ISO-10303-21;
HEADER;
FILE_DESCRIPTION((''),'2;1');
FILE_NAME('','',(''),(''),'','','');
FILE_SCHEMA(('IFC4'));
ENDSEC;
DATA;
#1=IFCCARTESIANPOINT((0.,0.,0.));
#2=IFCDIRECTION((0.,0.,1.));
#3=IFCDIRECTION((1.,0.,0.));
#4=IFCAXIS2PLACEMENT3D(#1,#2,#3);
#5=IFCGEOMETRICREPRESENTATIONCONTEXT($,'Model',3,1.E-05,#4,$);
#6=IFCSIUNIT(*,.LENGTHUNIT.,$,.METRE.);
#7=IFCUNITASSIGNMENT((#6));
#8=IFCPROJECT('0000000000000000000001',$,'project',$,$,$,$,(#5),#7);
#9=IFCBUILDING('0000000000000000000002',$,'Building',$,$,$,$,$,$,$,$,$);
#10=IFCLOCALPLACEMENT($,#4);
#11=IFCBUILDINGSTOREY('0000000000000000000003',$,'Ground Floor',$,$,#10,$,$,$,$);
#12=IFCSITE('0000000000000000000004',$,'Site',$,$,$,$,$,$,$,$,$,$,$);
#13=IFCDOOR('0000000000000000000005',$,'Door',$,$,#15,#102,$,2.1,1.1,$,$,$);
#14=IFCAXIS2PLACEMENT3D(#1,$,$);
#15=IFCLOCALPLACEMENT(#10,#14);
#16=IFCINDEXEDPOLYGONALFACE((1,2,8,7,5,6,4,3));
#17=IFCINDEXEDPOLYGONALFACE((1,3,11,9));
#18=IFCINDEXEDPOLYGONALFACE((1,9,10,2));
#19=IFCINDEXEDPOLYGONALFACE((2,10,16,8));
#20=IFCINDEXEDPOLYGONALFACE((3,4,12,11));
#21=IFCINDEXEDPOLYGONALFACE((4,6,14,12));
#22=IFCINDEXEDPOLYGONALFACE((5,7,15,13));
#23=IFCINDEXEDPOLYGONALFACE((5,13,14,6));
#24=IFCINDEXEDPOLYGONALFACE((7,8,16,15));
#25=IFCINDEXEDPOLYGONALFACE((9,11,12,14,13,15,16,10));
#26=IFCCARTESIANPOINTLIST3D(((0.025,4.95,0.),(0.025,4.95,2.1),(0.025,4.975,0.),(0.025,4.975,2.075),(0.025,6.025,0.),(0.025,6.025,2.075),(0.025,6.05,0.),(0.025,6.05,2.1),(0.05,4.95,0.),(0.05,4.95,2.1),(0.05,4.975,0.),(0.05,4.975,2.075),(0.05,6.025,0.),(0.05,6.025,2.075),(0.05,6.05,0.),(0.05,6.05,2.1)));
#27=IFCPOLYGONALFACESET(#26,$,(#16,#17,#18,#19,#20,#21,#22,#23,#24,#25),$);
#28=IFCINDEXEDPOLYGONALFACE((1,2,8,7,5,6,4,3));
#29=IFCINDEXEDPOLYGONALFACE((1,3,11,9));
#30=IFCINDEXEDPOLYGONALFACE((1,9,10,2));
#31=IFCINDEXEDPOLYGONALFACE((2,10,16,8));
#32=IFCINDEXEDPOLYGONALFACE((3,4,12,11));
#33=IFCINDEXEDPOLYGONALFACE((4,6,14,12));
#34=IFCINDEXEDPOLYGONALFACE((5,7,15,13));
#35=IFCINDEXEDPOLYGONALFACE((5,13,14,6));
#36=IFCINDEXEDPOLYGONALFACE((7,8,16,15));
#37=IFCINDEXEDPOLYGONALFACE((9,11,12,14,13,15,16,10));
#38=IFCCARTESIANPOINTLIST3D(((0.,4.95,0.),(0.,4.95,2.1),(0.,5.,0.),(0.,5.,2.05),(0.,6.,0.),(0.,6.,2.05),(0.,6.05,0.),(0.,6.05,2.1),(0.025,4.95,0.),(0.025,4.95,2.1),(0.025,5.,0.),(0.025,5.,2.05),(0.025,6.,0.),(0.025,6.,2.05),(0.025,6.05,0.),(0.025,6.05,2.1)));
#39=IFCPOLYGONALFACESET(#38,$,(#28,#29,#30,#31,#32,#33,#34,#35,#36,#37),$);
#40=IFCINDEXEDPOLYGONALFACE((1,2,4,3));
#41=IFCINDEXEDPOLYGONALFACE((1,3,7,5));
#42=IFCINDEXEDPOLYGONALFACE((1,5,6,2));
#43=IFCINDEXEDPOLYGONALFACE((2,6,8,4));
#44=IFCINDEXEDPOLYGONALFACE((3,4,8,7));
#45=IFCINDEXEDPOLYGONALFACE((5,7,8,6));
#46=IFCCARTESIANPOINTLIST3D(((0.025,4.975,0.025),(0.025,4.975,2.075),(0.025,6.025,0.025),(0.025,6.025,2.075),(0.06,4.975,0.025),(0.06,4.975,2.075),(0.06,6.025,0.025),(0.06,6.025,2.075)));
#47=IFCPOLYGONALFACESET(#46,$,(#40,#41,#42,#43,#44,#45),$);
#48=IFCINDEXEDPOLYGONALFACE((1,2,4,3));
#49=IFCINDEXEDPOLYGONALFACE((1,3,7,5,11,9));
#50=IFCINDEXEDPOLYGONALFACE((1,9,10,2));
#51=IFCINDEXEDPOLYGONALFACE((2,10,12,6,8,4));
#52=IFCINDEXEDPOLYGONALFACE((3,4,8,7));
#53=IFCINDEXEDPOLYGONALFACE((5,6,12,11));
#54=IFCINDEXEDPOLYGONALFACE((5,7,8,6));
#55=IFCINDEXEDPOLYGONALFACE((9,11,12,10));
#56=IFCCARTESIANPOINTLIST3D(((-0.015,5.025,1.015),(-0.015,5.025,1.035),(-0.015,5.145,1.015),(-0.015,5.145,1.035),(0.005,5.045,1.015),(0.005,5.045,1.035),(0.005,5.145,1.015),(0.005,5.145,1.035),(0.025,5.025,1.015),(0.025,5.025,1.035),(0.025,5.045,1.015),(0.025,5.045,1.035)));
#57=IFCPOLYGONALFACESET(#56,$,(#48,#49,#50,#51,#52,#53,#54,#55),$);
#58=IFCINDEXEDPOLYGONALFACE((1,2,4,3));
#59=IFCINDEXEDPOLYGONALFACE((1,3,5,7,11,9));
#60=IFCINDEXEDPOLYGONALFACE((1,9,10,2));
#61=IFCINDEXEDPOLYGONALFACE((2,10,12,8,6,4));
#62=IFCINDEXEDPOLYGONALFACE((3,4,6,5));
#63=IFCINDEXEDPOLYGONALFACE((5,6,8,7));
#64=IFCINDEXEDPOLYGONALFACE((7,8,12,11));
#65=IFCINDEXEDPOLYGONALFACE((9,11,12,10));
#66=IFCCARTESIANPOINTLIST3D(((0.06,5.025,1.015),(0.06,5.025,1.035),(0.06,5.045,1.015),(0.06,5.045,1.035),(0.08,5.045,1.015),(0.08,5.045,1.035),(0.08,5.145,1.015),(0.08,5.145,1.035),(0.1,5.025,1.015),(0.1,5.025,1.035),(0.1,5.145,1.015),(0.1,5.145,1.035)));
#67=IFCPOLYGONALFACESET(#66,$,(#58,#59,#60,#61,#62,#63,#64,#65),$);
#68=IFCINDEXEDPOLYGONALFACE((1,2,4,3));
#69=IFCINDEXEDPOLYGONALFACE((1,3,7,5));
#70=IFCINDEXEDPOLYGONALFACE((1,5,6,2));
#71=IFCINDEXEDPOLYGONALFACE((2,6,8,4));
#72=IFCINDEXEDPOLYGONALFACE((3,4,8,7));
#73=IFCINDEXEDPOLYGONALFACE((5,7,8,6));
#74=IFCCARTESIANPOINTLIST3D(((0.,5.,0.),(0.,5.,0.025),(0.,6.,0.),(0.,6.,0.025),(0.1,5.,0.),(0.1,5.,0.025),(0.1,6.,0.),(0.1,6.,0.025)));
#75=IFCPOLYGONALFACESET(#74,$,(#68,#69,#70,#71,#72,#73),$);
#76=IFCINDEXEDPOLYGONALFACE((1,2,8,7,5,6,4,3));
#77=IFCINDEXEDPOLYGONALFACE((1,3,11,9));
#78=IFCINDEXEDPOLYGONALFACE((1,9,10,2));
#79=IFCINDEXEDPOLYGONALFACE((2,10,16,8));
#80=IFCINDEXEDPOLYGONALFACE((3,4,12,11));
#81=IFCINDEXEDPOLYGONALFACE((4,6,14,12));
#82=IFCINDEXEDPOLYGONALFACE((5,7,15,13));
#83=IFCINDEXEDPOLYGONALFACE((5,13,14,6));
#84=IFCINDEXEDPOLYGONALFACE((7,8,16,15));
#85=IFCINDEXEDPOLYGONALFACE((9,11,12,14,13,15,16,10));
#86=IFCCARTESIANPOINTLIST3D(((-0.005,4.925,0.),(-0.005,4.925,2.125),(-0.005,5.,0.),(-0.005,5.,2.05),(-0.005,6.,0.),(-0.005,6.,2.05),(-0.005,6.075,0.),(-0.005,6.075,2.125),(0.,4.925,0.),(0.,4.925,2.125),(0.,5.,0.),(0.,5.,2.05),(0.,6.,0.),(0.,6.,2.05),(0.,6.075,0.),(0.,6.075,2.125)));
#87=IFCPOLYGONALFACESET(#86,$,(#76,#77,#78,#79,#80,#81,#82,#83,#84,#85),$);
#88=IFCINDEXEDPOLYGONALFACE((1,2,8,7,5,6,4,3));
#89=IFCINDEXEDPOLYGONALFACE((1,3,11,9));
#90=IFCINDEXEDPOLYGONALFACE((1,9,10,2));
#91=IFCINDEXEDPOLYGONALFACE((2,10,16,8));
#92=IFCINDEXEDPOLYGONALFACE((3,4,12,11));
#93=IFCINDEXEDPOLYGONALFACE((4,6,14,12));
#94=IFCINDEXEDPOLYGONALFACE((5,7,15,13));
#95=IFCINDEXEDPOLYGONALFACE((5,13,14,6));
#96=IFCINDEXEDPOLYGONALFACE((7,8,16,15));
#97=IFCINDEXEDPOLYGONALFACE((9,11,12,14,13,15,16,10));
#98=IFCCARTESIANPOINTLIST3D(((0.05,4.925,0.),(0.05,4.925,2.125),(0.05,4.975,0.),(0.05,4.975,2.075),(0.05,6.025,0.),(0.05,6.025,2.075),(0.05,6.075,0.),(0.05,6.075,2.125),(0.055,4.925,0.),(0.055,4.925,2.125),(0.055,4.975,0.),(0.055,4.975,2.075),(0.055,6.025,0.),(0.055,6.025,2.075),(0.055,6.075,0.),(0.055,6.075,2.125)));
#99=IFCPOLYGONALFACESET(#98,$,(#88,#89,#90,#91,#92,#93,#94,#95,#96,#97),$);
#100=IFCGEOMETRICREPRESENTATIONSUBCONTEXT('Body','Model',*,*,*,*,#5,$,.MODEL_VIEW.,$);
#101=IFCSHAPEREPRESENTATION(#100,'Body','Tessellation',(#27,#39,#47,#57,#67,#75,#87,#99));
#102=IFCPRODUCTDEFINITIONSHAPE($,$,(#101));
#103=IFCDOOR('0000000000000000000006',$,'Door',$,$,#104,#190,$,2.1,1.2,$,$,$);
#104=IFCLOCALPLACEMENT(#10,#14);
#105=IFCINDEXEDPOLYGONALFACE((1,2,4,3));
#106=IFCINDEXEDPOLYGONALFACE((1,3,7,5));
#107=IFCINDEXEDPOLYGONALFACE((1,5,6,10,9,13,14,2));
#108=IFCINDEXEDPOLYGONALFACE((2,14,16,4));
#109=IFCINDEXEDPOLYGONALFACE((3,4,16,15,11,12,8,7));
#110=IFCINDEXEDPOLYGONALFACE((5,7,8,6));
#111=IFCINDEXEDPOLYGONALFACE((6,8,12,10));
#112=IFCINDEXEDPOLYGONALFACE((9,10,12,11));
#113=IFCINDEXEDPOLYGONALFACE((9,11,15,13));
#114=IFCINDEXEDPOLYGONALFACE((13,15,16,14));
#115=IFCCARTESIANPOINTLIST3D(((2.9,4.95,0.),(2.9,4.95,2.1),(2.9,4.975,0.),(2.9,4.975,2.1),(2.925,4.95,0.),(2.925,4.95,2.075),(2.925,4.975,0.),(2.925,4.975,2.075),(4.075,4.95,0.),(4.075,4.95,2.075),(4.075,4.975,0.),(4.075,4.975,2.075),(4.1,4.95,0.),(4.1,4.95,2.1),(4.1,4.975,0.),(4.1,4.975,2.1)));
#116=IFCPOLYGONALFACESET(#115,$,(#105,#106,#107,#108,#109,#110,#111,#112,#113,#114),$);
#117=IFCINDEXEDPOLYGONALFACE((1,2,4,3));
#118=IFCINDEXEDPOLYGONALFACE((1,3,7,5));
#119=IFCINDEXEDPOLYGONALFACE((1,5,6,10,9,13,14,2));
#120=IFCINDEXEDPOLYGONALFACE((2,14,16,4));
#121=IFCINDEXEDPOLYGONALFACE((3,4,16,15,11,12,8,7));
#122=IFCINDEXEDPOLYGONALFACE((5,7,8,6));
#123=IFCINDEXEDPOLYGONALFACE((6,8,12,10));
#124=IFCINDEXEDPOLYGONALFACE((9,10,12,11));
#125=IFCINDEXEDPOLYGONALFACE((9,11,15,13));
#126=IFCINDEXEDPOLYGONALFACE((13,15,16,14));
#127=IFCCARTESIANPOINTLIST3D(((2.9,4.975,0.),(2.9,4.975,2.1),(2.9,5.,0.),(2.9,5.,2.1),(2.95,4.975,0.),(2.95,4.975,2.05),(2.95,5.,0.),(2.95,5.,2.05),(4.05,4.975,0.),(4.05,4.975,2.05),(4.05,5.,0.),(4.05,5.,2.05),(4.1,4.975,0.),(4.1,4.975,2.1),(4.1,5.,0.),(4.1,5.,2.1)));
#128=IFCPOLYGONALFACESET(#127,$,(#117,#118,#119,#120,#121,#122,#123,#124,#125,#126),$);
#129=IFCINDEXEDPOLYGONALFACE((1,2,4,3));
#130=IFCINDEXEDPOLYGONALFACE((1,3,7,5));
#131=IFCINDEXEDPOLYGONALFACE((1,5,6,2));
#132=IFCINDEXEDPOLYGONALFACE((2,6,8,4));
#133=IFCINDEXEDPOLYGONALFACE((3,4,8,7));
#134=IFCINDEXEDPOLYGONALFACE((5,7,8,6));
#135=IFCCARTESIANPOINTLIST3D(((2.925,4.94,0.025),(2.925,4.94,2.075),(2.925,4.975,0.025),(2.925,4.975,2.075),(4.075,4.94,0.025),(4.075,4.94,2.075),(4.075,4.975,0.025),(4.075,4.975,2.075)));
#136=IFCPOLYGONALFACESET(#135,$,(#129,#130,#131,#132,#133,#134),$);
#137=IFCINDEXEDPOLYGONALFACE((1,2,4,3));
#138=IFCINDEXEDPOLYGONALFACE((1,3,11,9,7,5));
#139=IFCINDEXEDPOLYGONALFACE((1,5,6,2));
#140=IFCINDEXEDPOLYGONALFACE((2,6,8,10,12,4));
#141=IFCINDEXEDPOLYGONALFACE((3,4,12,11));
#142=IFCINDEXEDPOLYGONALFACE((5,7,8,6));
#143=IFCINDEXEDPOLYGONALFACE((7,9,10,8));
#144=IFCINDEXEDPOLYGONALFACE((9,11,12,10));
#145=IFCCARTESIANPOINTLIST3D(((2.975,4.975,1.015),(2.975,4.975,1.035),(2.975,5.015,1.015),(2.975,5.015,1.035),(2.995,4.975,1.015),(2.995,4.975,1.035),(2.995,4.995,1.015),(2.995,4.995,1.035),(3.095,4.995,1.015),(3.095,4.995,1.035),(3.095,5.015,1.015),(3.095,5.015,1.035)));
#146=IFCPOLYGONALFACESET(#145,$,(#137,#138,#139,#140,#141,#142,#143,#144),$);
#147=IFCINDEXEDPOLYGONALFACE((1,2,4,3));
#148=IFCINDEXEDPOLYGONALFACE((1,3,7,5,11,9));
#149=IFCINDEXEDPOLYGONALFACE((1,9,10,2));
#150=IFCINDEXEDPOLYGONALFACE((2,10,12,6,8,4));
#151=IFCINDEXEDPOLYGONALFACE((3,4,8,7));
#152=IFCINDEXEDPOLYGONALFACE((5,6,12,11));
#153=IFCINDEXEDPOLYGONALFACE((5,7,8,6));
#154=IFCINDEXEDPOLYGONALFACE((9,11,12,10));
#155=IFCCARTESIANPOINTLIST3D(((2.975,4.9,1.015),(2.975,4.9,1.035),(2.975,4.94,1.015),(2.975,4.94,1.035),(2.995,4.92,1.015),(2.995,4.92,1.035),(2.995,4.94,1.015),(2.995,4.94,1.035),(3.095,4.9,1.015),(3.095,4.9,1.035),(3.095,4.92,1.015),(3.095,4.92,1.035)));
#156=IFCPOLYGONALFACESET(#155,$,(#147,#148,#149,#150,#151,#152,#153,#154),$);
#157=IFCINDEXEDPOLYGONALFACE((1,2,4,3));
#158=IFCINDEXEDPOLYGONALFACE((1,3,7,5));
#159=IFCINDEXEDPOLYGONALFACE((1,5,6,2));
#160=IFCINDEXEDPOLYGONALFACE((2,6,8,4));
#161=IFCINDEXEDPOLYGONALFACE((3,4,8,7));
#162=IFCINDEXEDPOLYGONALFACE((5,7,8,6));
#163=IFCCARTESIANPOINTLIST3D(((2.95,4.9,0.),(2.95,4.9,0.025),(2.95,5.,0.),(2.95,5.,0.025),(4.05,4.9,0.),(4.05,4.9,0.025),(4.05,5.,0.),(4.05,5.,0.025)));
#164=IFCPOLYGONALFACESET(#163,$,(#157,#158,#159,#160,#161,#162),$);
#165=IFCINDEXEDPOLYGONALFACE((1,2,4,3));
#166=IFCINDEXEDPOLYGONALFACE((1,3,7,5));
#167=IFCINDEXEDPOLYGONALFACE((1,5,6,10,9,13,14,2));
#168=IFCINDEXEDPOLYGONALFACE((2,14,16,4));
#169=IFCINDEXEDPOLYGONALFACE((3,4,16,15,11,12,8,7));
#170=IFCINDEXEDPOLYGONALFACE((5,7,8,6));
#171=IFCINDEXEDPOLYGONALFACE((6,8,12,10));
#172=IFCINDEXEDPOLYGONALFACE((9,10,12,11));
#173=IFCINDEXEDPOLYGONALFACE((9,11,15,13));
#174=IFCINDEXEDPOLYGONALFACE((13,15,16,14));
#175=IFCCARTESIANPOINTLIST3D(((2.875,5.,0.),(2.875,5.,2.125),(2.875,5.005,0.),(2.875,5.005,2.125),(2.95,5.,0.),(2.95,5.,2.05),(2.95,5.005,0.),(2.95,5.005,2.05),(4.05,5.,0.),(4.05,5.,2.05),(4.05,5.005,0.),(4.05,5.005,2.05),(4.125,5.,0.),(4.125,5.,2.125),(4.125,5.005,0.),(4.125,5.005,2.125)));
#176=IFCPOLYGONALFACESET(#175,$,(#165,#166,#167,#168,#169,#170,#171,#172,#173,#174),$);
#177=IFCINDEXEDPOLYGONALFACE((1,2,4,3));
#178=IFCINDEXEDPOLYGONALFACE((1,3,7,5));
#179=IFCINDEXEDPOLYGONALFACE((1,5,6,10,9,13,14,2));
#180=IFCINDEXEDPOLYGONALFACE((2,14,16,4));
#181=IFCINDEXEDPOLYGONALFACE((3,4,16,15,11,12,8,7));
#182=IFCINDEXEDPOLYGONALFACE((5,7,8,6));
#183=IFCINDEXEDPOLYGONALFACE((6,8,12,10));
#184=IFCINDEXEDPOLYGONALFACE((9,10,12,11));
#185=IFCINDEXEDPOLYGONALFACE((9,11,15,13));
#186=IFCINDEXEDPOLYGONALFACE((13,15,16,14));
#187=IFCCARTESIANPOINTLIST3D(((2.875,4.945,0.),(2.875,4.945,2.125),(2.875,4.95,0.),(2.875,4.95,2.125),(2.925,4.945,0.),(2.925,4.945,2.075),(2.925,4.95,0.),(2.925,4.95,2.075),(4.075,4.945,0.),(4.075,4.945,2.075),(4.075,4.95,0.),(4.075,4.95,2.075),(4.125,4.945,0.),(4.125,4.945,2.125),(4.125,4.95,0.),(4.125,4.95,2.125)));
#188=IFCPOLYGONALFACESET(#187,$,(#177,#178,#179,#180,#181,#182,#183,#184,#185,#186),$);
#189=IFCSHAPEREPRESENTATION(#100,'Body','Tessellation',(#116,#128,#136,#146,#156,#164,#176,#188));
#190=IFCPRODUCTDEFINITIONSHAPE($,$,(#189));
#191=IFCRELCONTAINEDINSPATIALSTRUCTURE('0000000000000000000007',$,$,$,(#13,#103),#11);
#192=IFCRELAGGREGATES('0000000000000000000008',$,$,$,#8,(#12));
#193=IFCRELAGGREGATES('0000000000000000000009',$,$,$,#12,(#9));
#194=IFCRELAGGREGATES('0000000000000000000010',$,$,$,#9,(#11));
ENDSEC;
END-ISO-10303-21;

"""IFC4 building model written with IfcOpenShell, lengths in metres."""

from ifc_helpers import new_model, si_unit, frame, origin_with_axes, place, context, subcontext, project, spatial, line, indexed_curve, outline, extrude, element, save


model = new_model("IFC4")

# Units and contexts
model_context = context("Model", 3, precision=1e-05, world=origin_with_axes())
body_context = subcontext(model_context, "Body", "Model", "MODEL_VIEW")
ifc_project = project(units=[si_unit("LENGTHUNIT", "METRE")], contexts=[model_context])

# Site, building, storey
site = spatial("IfcSite", under=ifc_project, Name="Site")
building = spatial("IfcBuilding", under=site, Name="Building")
storey_placement = place(None, origin_with_axes())
storey = spatial("IfcBuildingStorey", under=building, at=storey_placement, Name="Ground Floor")

# Doors
door_1_placement = place(storey_placement, frame((0.0, 6.05, 0.0), z_axis=(0.0, 0.0, 1.0), x_axis=(0.0, -1.0, 0.0)))
element("IfcDoor", 1, at=door_1_placement, inside=storey, Name="Door", OverallHeight=2.1, OverallWidth=1.1, context=body_context, shape_type="SweptSolid", body=[
    extrude(outline(indexed_curve([(0.0, 0.0), (0.0, 2.1), (1.1, 2.1), (1.1, 0.0), (1.075, 0.0), (1.075, 2.075), (0.025, 2.075), (0.025, 0.0)], segments=[line(1, 2, 3, 4, 5, 6, 7, 8, 1)])), frame((0.0, 0.025, 0.0), z_axis=(0.0, -1.0, 0.0), x_axis=(1.0, 0.0, 0.0)), (0.0, 0.0, -1.0), 0.025),
    extrude(outline(indexed_curve([(0.0, 0.0), (0.0, 2.1), (1.1, 2.1), (1.1, 0.0), (1.05, 0.0), (1.05, 2.05), (0.05, 2.05), (0.05, 0.0)], segments=[line(1, 2, 3, 4, 5, 6, 7, 8, 1)])), frame((0.0, 0.0, 0.0), z_axis=(0.0, -1.0, 0.0), x_axis=(1.0, 0.0, 0.0)), (0.0, 0.0, -1.0), 0.025),
    extrude(outline(indexed_curve([(0.0, 0.0), (1.05, 0.0), (1.05, 0.035), (0.0, 0.035)], segments=[line(1, 2, 3, 4, 1)])), frame((0.025, 0.025, 0.025), z_axis=(0.0, 0.0, 1.0), x_axis=(1.0, 0.0, 0.0)), (0.0, 0.0, 1.0), 2.05),
    extrude(outline(indexed_curve([(0.0, 0.0), (0.0, -0.04), (-0.12, -0.04), (-0.12, -0.02), (-0.02, -0.02), (-0.02, 0.0)], segments=[line(1, 2, 3, 4, 5, 6, 1)])), frame((1.025, 0.025, 1.015), z_axis=(0.0, 0.0, 1.0), x_axis=(1.0, 0.0, 0.0)), (0.0, 0.0, 1.0), 0.02),
    extrude(outline(indexed_curve([(0.0, 0.0), (0.0, 0.04), (-0.12, 0.04), (-0.12, 0.02), (-0.02, 0.02), (-0.02, 0.0)], segments=[line(1, 2, 3, 4, 5, 6, 1)])), frame((1.025, 0.06, 1.015), z_axis=(0.0, 0.0, 1.0), x_axis=(1.0, 0.0, 0.0)), (0.0, 0.0, 1.0), 0.02),
    extrude(outline(indexed_curve([(0.0, 0.0), (1.0, 0.0), (1.0, 0.1), (0.0, 0.1)], segments=[line(1, 2, 3, 4, 1)])), frame((0.05, 0.0, 0.0), z_axis=(0.0, 0.0, 1.0), x_axis=(1.0, 0.0, 0.0)), (0.0, 0.0, 1.0), 0.025),
    extrude(outline(indexed_curve([(0.0, 0.0), (0.0, 2.125), (1.15, 2.125), (1.15, 0.0), (1.075, 0.0), (1.075, 2.05), (0.075, 2.05), (0.075, 0.0)], segments=[line(1, 2, 3, 4, 5, 6, 7, 8, 1)])), frame((-0.025, -0.005, 0.0), z_axis=(0.0, -1.0, 0.0), x_axis=(1.0, 0.0, 0.0)), (0.0, 0.0, -1.0), 0.005),
    extrude(outline(indexed_curve([(0.0, 0.0), (0.0, 2.125), (1.15, 2.125), (1.15, 0.0), (1.1, 0.0), (1.1, 2.075), (0.05, 2.075), (0.05, 0.0)], segments=[line(1, 2, 3, 4, 5, 6, 7, 8, 1)])), frame((-0.025, 0.05, 0.0), z_axis=(0.0, -1.0, 0.0), x_axis=(1.0, 0.0, 0.0)), (0.0, 0.0, -1.0), 0.005),
])
door_2_placement = place(storey_placement, frame((4.1, 5.0, 0.0), z_axis=(0.0, 0.0, 1.0), x_axis=(-1.0, 0.0, 0.0)))
element("IfcDoor", 2, at=door_2_placement, inside=storey, Name="Door", OverallHeight=2.1, OverallWidth=1.2, context=body_context, shape_type="SweptSolid", body=[
    extrude(outline(indexed_curve([(0.0, 0.0), (0.0, 2.1), (1.2, 2.1), (1.2, 0.0), (1.175, 0.0), (1.175, 2.075), (0.025, 2.075), (0.025, 0.0)], segments=[line(1, 2, 3, 4, 5, 6, 7, 8, 1)])), frame((0.0, 0.025, 0.0), z_axis=(0.0, -1.0, 0.0), x_axis=(1.0, 0.0, 0.0)), (0.0, 0.0, -1.0), 0.025),
    extrude(outline(indexed_curve([(0.0, 0.0), (0.0, 2.1), (1.2, 2.1), (1.2, 0.0), (1.15, 0.0), (1.15, 2.05), (0.05, 2.05), (0.05, 0.0)], segments=[line(1, 2, 3, 4, 5, 6, 7, 8, 1)])), frame((0.0, 0.0, 0.0), z_axis=(0.0, -1.0, 0.0), x_axis=(1.0, 0.0, 0.0)), (0.0, 0.0, -1.0), 0.025),
    extrude(outline(indexed_curve([(0.0, 0.0), (1.15, 0.0), (1.15, 0.035), (0.0, 0.035)], segments=[line(1, 2, 3, 4, 1)])), frame((0.025, 0.025, 0.025), z_axis=(0.0, 0.0, 1.0), x_axis=(1.0, 0.0, 0.0)), (0.0, 0.0, 1.0), 2.05),
    extrude(outline(indexed_curve([(0.0, 0.0), (0.0, -0.04), (-0.12, -0.04), (-0.12, -0.02), (-0.02, -0.02), (-0.02, 0.0)], segments=[line(1, 2, 3, 4, 5, 6, 1)])), frame((1.125, 0.025, 1.015), z_axis=(0.0, 0.0, 1.0), x_axis=(1.0, 0.0, 0.0)), (0.0, 0.0, 1.0), 0.02),
    extrude(outline(indexed_curve([(0.0, 0.0), (0.0, 0.04), (-0.12, 0.04), (-0.12, 0.02), (-0.02, 0.02), (-0.02, 0.0)], segments=[line(1, 2, 3, 4, 5, 6, 1)])), frame((1.125, 0.06, 1.015), z_axis=(0.0, 0.0, 1.0), x_axis=(1.0, 0.0, 0.0)), (0.0, 0.0, 1.0), 0.02),
    extrude(outline(indexed_curve([(0.0, 0.0), (1.1, 0.0), (1.1, 0.1), (0.0, 0.1)], segments=[line(1, 2, 3, 4, 1)])), frame((0.05, 0.0, 0.0), z_axis=(0.0, 0.0, 1.0), x_axis=(1.0, 0.0, 0.0)), (0.0, 0.0, 1.0), 0.025),
    extrude(outline(indexed_curve([(0.0, 0.0), (0.0, 2.125), (1.25, 2.125), (1.25, 0.0), (1.175, 0.0), (1.175, 2.05), (0.075, 2.05), (0.075, 0.0)], segments=[line(1, 2, 3, 4, 5, 6, 7, 8, 1)])), frame((-0.025, -0.005, 0.0), z_axis=(0.0, -1.0, 0.0), x_axis=(1.0, 0.0, 0.0)), (0.0, 0.0, -1.0), 0.005),
    extrude(outline(indexed_curve([(0.0, 0.0), (0.0, 2.125), (1.25, 2.125), (1.25, 0.0), (1.2, 0.0), (1.2, 2.075), (0.05, 2.075), (0.05, 0.0)], segments=[line(1, 2, 3, 4, 5, 6, 7, 8, 1)])), frame((-0.025, 0.05, 0.0), z_axis=(0.0, -1.0, 0.0), x_axis=(1.0, 0.0, 0.0)), (0.0, 0.0, -1.0), 0.005),
])

save(model, "model.ifc")
